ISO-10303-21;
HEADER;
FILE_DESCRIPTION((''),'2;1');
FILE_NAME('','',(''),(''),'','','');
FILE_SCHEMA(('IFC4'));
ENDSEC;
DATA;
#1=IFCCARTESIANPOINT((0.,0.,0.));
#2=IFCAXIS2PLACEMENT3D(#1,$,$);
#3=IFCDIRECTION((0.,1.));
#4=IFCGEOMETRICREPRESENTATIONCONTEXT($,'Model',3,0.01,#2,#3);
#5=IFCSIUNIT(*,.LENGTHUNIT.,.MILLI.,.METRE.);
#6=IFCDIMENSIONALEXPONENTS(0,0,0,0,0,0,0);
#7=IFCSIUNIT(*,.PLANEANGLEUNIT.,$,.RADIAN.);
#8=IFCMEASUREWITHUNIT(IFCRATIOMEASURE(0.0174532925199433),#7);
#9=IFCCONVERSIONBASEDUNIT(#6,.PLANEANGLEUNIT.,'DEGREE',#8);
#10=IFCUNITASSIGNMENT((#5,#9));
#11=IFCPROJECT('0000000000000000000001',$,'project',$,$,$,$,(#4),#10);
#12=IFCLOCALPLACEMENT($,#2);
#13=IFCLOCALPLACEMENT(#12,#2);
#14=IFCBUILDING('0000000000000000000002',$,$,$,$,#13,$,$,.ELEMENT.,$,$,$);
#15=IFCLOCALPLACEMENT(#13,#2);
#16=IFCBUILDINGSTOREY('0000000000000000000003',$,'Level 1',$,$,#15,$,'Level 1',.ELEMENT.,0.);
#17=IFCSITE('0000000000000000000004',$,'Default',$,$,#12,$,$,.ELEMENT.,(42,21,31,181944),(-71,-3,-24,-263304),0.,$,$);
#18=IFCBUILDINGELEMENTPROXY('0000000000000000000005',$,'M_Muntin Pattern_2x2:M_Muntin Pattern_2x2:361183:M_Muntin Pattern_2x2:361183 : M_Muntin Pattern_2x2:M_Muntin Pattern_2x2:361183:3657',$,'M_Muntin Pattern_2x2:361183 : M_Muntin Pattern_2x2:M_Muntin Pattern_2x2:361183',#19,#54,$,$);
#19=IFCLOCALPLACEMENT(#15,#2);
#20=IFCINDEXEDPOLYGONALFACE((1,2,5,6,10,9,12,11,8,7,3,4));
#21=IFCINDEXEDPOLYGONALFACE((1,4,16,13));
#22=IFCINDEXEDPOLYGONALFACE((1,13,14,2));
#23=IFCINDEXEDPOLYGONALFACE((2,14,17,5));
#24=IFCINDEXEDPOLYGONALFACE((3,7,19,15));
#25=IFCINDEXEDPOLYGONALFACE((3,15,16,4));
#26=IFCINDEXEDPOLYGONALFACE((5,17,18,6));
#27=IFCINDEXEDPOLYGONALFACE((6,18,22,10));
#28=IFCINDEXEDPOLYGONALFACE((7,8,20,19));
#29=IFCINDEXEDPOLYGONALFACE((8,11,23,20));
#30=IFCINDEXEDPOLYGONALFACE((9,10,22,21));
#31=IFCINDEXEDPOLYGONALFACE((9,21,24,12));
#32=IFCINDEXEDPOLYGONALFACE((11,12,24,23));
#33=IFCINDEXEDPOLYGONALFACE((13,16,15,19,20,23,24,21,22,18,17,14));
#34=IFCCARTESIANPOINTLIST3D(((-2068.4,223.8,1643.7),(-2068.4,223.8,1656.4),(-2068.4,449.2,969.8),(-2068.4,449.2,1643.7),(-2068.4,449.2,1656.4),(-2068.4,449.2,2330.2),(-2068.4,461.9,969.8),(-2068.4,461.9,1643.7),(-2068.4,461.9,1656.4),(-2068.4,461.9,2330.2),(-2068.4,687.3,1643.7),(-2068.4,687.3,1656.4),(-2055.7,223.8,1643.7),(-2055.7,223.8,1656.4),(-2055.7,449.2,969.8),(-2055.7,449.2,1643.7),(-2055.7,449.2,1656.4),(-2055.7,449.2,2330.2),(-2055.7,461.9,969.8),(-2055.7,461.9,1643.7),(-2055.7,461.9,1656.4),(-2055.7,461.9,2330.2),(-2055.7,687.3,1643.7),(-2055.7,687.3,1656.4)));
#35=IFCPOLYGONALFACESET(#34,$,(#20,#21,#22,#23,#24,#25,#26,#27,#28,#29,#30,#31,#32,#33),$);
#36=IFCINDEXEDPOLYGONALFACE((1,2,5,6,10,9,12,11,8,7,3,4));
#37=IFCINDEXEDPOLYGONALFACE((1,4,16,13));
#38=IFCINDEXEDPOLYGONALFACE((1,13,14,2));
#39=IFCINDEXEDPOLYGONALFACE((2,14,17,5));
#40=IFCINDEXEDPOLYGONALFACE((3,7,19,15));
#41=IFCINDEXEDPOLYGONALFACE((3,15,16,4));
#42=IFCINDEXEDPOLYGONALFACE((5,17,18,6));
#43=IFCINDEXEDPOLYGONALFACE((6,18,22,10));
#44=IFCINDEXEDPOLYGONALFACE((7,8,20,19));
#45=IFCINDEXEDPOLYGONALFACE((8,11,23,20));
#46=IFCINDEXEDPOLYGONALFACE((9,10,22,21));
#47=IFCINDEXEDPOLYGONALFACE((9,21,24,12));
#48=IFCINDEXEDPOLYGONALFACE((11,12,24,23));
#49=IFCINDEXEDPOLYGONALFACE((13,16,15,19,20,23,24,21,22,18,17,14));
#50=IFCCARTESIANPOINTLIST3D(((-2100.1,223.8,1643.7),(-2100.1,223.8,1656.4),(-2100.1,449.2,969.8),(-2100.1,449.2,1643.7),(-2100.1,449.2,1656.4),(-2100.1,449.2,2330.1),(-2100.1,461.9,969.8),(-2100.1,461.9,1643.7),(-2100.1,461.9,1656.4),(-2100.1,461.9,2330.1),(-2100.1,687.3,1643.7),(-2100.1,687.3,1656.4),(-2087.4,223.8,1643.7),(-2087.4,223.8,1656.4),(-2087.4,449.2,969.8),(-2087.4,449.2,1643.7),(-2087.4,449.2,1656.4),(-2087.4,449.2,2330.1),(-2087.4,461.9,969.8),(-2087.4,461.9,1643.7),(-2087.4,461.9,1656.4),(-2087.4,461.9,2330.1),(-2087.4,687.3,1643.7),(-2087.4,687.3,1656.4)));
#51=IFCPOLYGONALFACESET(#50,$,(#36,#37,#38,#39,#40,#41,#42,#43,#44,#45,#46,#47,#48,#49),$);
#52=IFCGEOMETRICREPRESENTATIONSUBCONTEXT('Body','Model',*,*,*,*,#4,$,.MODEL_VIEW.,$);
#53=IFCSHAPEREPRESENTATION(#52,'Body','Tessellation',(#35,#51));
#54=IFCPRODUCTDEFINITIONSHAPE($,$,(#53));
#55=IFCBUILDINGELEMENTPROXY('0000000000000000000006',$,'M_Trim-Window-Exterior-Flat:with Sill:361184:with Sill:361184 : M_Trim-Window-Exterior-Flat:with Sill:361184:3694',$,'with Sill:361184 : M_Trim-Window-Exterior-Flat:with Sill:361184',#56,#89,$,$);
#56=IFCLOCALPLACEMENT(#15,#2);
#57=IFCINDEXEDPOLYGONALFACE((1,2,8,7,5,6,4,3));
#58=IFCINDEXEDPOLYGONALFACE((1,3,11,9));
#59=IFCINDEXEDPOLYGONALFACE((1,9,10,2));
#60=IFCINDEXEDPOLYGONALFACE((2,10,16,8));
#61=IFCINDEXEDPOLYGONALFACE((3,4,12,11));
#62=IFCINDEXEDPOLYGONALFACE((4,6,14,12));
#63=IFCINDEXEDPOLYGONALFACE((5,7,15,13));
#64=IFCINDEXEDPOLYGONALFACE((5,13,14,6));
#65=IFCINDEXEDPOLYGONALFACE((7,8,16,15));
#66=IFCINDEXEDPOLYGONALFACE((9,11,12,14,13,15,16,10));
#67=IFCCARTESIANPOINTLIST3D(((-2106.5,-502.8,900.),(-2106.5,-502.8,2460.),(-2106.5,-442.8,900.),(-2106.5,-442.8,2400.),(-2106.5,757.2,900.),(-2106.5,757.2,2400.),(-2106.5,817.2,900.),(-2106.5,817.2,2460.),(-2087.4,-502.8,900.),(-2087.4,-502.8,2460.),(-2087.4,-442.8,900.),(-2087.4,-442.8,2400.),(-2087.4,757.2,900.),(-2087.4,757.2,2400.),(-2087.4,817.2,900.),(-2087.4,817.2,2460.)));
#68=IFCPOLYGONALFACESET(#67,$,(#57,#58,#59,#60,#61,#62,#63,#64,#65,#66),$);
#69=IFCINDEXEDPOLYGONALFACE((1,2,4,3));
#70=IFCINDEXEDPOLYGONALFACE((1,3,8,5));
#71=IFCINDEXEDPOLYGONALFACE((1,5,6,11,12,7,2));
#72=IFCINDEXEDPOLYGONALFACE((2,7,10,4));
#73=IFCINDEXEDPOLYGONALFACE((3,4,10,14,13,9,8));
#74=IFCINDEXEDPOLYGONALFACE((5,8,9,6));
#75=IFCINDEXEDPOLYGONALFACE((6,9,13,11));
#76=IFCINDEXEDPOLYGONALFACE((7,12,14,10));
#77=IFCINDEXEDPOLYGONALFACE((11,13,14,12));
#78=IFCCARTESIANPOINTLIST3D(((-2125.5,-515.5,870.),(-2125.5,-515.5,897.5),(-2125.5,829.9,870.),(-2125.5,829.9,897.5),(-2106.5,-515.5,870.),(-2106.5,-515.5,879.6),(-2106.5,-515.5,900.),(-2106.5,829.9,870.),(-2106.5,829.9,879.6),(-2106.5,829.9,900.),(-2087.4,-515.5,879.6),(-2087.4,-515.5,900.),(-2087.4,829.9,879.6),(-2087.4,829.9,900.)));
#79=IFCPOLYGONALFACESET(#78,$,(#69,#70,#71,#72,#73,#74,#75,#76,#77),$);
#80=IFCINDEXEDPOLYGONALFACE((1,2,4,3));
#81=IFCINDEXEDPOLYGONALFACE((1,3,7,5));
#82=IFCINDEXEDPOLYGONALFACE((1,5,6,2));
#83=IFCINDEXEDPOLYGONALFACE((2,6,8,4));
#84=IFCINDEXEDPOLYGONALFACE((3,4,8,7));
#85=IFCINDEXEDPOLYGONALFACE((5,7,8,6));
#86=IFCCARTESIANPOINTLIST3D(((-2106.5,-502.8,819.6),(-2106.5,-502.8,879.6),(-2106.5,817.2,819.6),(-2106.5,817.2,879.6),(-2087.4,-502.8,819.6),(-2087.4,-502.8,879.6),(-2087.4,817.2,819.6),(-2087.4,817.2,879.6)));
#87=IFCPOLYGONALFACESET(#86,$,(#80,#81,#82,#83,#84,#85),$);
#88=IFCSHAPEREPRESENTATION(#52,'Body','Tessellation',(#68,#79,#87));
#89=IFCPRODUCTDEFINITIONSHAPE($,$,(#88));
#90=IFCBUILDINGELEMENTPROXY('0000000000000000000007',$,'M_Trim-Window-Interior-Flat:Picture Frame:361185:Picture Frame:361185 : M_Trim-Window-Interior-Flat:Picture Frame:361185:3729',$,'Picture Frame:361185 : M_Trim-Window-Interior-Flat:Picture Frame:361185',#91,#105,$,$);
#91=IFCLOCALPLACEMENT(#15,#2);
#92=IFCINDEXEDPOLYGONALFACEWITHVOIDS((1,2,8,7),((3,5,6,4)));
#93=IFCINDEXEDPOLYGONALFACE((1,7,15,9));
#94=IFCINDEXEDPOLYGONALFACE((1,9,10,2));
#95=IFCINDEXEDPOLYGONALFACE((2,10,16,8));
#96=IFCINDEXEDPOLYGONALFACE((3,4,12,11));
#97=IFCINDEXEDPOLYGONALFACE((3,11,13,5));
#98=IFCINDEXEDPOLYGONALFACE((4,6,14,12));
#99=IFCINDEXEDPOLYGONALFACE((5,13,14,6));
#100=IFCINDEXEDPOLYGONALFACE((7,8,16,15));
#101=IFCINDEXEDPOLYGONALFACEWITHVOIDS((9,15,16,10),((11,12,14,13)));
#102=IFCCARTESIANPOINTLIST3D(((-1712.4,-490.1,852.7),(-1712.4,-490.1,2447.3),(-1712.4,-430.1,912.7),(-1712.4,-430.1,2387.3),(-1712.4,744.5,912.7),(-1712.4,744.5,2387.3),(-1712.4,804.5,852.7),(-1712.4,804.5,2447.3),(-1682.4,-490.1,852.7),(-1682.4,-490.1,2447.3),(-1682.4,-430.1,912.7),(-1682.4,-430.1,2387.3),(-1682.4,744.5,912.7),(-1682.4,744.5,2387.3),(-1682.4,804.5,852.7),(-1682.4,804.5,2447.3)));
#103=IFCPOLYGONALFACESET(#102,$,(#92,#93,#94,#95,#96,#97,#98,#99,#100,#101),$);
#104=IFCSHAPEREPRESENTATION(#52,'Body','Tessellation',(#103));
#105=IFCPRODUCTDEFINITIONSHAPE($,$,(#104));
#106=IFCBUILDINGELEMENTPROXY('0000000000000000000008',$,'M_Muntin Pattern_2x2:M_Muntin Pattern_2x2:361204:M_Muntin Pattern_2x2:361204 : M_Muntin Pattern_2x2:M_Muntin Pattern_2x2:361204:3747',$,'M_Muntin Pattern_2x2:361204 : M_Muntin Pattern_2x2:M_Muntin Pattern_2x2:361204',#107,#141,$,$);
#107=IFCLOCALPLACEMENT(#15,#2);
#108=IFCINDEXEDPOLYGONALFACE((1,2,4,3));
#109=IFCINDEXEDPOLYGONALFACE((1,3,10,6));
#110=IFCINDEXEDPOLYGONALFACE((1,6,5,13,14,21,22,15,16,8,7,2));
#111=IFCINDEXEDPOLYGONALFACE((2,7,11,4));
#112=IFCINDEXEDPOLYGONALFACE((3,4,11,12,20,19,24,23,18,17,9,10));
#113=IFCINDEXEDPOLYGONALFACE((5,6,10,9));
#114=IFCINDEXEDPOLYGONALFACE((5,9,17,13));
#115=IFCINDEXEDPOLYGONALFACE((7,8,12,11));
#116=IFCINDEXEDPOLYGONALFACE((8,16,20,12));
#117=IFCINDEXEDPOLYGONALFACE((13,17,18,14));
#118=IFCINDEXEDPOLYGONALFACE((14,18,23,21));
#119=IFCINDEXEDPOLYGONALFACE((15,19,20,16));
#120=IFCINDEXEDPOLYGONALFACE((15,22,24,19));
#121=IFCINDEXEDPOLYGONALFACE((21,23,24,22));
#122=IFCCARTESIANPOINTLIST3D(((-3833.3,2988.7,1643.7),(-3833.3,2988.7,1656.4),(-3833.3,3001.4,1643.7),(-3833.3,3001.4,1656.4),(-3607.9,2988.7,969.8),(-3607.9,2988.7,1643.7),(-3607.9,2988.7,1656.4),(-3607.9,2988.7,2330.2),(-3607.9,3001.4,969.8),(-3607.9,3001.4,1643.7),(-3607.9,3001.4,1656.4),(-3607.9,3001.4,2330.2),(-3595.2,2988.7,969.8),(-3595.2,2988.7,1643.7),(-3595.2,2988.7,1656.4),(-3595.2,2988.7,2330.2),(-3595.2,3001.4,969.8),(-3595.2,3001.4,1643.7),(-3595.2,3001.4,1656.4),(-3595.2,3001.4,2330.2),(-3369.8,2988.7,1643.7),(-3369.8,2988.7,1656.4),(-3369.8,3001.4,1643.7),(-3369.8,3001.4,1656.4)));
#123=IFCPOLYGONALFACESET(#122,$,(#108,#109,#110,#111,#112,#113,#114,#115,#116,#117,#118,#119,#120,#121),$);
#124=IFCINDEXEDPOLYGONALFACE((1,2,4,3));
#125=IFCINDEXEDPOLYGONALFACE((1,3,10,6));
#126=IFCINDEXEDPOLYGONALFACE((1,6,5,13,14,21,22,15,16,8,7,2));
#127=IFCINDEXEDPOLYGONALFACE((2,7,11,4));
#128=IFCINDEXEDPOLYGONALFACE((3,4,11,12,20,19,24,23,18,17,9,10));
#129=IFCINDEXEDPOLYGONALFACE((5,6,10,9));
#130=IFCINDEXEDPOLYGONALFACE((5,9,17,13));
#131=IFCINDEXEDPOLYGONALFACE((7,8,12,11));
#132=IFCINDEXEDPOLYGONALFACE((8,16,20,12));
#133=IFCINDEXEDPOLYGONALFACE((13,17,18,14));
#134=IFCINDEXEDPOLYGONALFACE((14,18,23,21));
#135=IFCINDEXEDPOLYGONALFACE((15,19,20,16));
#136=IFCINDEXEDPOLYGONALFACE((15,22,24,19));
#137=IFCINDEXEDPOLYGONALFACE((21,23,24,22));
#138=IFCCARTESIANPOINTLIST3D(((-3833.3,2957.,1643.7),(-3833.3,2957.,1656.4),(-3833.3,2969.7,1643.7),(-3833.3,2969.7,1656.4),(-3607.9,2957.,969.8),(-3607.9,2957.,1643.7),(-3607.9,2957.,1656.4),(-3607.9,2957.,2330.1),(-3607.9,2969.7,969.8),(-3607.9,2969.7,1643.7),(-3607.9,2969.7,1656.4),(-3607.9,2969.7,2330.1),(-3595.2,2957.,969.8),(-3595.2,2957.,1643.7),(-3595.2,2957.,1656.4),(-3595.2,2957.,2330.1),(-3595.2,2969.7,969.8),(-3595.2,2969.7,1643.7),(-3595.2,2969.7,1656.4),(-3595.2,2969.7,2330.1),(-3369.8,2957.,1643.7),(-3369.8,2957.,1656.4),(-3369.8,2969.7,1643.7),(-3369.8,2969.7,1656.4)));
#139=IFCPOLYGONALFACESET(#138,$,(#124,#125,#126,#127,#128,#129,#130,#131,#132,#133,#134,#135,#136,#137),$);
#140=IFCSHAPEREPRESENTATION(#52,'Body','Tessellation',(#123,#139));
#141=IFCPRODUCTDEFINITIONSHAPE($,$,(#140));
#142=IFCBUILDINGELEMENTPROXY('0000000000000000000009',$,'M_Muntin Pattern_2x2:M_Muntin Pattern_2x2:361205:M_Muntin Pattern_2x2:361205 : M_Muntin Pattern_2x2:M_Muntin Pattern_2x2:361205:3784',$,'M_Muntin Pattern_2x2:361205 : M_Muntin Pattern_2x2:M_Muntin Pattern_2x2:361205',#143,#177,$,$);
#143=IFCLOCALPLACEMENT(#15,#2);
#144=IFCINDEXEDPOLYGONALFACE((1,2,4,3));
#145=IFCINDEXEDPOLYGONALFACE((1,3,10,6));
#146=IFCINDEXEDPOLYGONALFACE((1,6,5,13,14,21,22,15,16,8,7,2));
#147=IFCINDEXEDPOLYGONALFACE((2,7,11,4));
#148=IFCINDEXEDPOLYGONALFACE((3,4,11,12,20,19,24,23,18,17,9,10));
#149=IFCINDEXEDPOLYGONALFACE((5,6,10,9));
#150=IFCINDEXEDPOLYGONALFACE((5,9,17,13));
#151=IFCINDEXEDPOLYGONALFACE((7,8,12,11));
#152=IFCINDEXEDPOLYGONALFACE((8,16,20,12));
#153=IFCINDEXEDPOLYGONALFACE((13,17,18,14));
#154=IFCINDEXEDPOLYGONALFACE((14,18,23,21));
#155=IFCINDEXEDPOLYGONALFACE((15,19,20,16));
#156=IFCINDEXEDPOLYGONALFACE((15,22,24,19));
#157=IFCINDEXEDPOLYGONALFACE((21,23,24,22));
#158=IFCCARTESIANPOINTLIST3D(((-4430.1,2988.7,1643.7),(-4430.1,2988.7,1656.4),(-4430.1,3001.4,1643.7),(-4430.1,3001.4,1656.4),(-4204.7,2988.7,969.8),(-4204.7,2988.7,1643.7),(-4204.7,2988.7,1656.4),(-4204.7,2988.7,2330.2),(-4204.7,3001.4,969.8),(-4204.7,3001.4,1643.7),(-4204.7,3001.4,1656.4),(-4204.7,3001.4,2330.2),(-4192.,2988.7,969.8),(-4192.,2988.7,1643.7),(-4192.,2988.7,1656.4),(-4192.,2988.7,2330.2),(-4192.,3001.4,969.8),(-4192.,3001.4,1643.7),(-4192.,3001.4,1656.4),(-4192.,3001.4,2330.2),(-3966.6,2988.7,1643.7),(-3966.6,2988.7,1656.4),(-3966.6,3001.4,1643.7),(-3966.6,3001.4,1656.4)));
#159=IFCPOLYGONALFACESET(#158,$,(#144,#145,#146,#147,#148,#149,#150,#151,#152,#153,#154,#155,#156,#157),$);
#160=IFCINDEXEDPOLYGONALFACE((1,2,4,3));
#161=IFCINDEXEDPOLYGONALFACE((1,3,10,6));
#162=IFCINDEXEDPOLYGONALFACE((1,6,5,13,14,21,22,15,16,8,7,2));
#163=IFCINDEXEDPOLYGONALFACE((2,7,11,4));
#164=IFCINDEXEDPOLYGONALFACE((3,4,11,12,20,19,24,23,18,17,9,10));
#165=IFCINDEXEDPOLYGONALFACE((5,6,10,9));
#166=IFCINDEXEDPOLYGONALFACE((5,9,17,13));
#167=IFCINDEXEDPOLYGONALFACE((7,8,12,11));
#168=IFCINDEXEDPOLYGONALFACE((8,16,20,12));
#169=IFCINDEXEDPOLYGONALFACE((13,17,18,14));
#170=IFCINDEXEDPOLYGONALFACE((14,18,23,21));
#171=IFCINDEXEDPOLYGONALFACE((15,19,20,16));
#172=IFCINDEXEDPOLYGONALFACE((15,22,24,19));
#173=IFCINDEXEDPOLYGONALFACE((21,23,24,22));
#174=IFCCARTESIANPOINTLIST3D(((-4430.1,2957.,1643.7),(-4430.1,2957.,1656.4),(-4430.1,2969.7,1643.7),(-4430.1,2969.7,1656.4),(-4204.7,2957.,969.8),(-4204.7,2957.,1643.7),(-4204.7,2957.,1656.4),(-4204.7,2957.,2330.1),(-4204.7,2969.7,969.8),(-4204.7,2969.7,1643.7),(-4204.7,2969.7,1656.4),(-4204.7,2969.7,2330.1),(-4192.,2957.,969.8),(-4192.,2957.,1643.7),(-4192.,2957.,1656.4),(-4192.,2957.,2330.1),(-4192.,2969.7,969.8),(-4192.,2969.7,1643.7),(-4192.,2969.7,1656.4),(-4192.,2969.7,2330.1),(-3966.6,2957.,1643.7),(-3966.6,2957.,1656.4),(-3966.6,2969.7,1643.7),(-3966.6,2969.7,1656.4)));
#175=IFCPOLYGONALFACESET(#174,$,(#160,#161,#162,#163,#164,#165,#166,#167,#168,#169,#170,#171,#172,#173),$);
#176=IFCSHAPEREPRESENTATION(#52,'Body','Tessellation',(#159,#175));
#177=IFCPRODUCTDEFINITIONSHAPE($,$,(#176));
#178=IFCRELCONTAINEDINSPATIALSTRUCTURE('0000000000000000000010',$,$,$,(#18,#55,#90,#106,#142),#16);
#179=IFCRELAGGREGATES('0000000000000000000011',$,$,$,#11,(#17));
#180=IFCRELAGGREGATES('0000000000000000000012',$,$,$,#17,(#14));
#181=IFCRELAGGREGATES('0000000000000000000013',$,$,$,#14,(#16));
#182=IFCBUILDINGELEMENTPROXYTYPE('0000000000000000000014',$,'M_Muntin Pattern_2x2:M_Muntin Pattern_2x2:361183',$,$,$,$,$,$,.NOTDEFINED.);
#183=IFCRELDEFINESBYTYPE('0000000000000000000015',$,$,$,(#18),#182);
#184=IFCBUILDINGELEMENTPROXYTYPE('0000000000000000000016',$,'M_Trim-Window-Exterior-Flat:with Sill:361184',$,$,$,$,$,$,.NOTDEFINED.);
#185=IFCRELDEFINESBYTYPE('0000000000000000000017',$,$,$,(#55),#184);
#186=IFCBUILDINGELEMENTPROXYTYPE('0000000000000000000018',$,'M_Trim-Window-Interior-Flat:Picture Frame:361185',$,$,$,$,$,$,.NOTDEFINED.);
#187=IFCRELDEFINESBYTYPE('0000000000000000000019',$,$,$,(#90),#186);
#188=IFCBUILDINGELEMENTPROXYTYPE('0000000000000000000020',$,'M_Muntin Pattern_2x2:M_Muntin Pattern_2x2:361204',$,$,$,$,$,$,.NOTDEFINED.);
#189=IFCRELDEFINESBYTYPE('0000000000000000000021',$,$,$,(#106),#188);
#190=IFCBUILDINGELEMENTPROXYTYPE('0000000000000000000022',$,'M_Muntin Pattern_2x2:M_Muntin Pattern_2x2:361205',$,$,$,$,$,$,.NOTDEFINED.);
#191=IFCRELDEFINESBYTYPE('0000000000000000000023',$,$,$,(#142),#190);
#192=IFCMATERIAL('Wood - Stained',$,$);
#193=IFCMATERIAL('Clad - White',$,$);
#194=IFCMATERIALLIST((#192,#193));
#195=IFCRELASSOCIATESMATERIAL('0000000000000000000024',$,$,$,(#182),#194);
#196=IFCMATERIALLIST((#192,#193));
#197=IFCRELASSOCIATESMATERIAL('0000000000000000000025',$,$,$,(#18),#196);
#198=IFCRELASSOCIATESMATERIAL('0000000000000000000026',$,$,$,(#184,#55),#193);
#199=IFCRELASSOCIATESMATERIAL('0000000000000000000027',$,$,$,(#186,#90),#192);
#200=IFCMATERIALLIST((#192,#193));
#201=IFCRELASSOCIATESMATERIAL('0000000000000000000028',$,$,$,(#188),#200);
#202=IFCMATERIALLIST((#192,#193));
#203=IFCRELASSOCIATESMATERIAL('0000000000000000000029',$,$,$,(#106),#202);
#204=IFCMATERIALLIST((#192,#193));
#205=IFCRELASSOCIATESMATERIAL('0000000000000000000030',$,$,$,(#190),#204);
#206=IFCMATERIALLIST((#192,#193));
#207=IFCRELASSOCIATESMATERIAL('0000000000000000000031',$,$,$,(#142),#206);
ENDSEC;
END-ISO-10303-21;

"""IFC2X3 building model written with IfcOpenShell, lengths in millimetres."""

from ifc_helpers import new_model, entity, si_unit, converted_unit, direction, frame, origin, origin_2d_with_axis, place, context, subcontext, project, spatial, polyline, rectangle, outline, extrude, source, transform, mapped, material, material_list, type_object, type_shapes, element, save


model = new_model("IFC2X3")

# Units and contexts
model_context = context("Model", 3, precision=0.01, world=origin(), true_north=direction((0.0, 1.0)))
body_context = subcontext(model_context, "Body", "Model", "MODEL_VIEW")
ifc_project = project(units=[si_unit("LENGTHUNIT", "METRE", prefix="MILLI"), converted_unit("PLANEANGLEUNIT", "DEGREE", entity("IfcRatioMeasure", 0.0174532925199433), si_unit("PLANEANGLEUNIT", "RADIAN"), dimensions=[0, 0, 0, 0, 0, 0, 0])], contexts=[model_context])

# Site, building, storey
site_placement = place(None, origin())
site = spatial("IfcSite", under=ifc_project, at=site_placement, Name="Default", CompositionType="ELEMENT", RefLatitude=(42, 21, 31, 181944), RefLongitude=(-71, -3, -24, -263304), RefElevation=0.0)
building_placement = place(site_placement, origin())
building = spatial("IfcBuilding", under=site, at=building_placement, CompositionType="ELEMENT")
storey_placement = place(building_placement, origin())
storey = spatial("IfcBuildingStorey", under=building, at=storey_placement, Name="Level 1", LongName="Level 1", CompositionType="ELEMENT", Elevation=0.0)

# Building element proxies
ifc_material_1 = material(Name="Wood - Stained")
ifc_material_2 = material(Name="Clad - White")
ifc_material_list_1 = material_list([ifc_material_1, ifc_material_2])
ifc_material_list_2 = material_list([ifc_material_1, ifc_material_2])
building_element_proxy_type_1 = type_object("IfcBuildingElementProxyType", Name="M_Muntin Pattern_2x2:M_Muntin Pattern_2x2:361183", PredefinedType="NOTDEFINED", material=ifc_material_list_2)
shared_shape_1 = source(origin(), body_context, "Body", "SweptSolid", [
    extrude(outline(polyline([(-6.4, -680.1), (6.3, -680.1), (6.3, -6.4), (231.7, -6.4), (231.7, 6.3), (6.3, 6.3), (6.3, 680.2), (-6.4, 680.2), (-6.4, 6.3), (-231.7, 6.3), (-231.7, -6.4), (-6.4, -6.4), (-6.4, -680.1)])), frame((-2068.4, 455.6, 1650.0), z_axis=(1.0, 0.0, 0.0), x_axis=(0.0, -1.0, 0.0)), (0.0, 0.0, 1.0), 12.7),
    extrude(outline(polyline([(-6.4, -680.1), (6.3, -680.1), (6.3, -6.4), (231.7, -6.4), (231.7, 6.3), (6.3, 6.3), (6.3, 680.2), (-6.4, 680.2), (-6.4, 6.3), (-231.7, 6.3), (-231.7, -6.4), (-6.4, -6.4), (-6.4, -680.1)])), frame((-2100.1, 455.6, 1650.0), z_axis=(1.0, 0.0, 0.0), x_axis=(0.0, -1.0, 0.0)), (0.0, 0.0, 1.0), 12.7),
])
type_shapes(building_element_proxy_type_1, [shared_shape_1])
proxy_1_placement = place(storey_placement, origin())
element("IfcBuildingElementProxy", 1, at=proxy_1_placement, inside=storey, type_object=building_element_proxy_type_1, material=ifc_material_list_1, Name="M_Muntin Pattern_2x2:M_Muntin Pattern_2x2:361183:M_Muntin Pattern_2x2:361183 : M_Muntin Pattern_2x2:M_Muntin Pattern_2x2:361183:3657", ObjectType="M_Muntin Pattern_2x2:361183 : M_Muntin Pattern_2x2:M_Muntin Pattern_2x2:361183", context=body_context, shape_type="MappedRepresentation", body=[
    mapped(shared_shape_1, transform((0.0, 0.0, 0.0), scale=1.0)),
])
building_element_proxy_type_2 = type_object("IfcBuildingElementProxyType", Name="M_Trim-Window-Exterior-Flat:with Sill:361184", PredefinedType="NOTDEFINED", material=ifc_material_2)
shared_shape_2 = source(origin(), body_context, "Body", "SweptSolid", [
    extrude(outline(polyline([(-765.0, -660.0), (795.0, -660.0), (795.0, 660.0), (-765.0, 660.0), (-765.0, 600.0), (735.0, 600.0), (735.0, -600.0), (-765.0, -600.0), (-765.0, -660.0)])), frame((-2106.5, 157.2, 1665.0), z_axis=(1.0, 0.0, 0.0), x_axis=(0.0, 0.0, 1.0)), (0.0, 0.0, 1.0), 19.1),
    extrude(outline(polyline([(0.0, -15.2), (19.0, -15.2), (19.0, 12.3), (0.0, 14.8), (-19.0, 14.8), (-19.0, -5.7), (0.0, -5.7), (0.0, -15.2)])), frame((-2106.5, -515.5, 885.2), z_axis=(0.0, 1.0, 0.0), x_axis=(-1.0, 0.0, 0.0)), (0.0, 0.0, 1.0), 1345.4),
    extrude(rectangle(XDim=19.1, YDim=1320.0, at=origin_2d_with_axis()), frame((-2097.0, 157.2, 819.6)), (0.0, 0.0, 1.0), 60.0),
])
type_shapes(building_element_proxy_type_2, [shared_shape_2])
proxy_2_placement = place(storey_placement, origin())
element("IfcBuildingElementProxy", 2, at=proxy_2_placement, inside=storey, type_object=building_element_proxy_type_2, material=ifc_material_2, Name="M_Trim-Window-Exterior-Flat:with Sill:361184:with Sill:361184 : M_Trim-Window-Exterior-Flat:with Sill:361184:3694", ObjectType="with Sill:361184 : M_Trim-Window-Exterior-Flat:with Sill:361184", context=body_context, shape_type="MappedRepresentation", body=[
    mapped(shared_shape_2, transform((0.0, 0.0, 0.0), scale=1.0)),
])
building_element_proxy_type_3 = type_object("IfcBuildingElementProxyType", Name="M_Trim-Window-Interior-Flat:Picture Frame:361185", PredefinedType="NOTDEFINED", material=ifc_material_1)
shared_shape_3 = source(origin(), body_context, "Body", "SweptSolid", [
    extrude(outline(polyline([(-797.3, -647.3), (797.3, -647.3), (797.3, 647.3), (-797.3, 647.3), (-797.3, -647.3)]), holes=[polyline([(737.3, 587.3), (737.3, -587.3), (-737.3, -587.3), (-737.3, 587.3), (737.3, 587.3)])]), frame((-1712.4, 157.2, 1650.0), z_axis=(1.0, 0.0, 0.0), x_axis=(0.0, 0.0, -1.0)), (0.0, 0.0, 1.0), 30.0),
])
type_shapes(building_element_proxy_type_3, [shared_shape_3])
proxy_3_placement = place(storey_placement, origin())
element("IfcBuildingElementProxy", 3, at=proxy_3_placement, inside=storey, type_object=building_element_proxy_type_3, material=ifc_material_1, Name="M_Trim-Window-Interior-Flat:Picture Frame:361185:Picture Frame:361185 : M_Trim-Window-Interior-Flat:Picture Frame:361185:3729", ObjectType="Picture Frame:361185 : M_Trim-Window-Interior-Flat:Picture Frame:361185", context=body_context, shape_type="MappedRepresentation", body=[
    mapped(shared_shape_3, transform((0.0, 0.0, 0.0), scale=1.0)),
])
ifc_material_list_3 = material_list([ifc_material_1, ifc_material_2])
ifc_material_list_4 = material_list([ifc_material_1, ifc_material_2])
building_element_proxy_type_4 = type_object("IfcBuildingElementProxyType", Name="M_Muntin Pattern_2x2:M_Muntin Pattern_2x2:361204", PredefinedType="NOTDEFINED", material=ifc_material_list_4)
shared_shape_4 = source(origin(), body_context, "Body", "SweptSolid", [
    extrude(outline(polyline([(-680.2, 6.4), (-680.2, -6.3), (-6.4, -6.3), (-6.4, -231.7), (6.3, -231.7), (6.3, -6.3), (680.2, -6.3), (680.2, 6.4), (6.3, 6.4), (6.3, 231.7), (-6.4, 231.7), (-6.4, 6.4), (-680.2, 6.4)])), frame((-3601.5, 2988.7, 1650.0), z_axis=(0.0, -1.0, 0.0), x_axis=(0.0, 0.0, -1.0)), (0.0, 0.0, -1.0), 12.7),
    extrude(outline(polyline([(-680.1, 6.4), (-680.1, -6.3), (-6.4, -6.3), (-6.4, -231.7), (6.3, -231.7), (6.3, -6.3), (680.2, -6.3), (680.2, 6.4), (6.3, 6.4), (6.3, 231.7), (-6.4, 231.7), (-6.4, 6.4), (-680.1, 6.4)])), frame((-3601.5, 2957.0, 1650.0), z_axis=(0.0, -1.0, 0.0), x_axis=(0.0, 0.0, -1.0)), (0.0, 0.0, -1.0), 12.7),
])
type_shapes(building_element_proxy_type_4, [shared_shape_4])
proxy_4_placement = place(storey_placement, origin())
element("IfcBuildingElementProxy", 4, at=proxy_4_placement, inside=storey, type_object=building_element_proxy_type_4, material=ifc_material_list_3, Name="M_Muntin Pattern_2x2:M_Muntin Pattern_2x2:361204:M_Muntin Pattern_2x2:361204 : M_Muntin Pattern_2x2:M_Muntin Pattern_2x2:361204:3747", ObjectType="M_Muntin Pattern_2x2:361204 : M_Muntin Pattern_2x2:M_Muntin Pattern_2x2:361204", context=body_context, shape_type="MappedRepresentation", body=[
    mapped(shared_shape_4, transform((0.0, 0.0, 0.0), scale=1.0)),
])
ifc_material_list_5 = material_list([ifc_material_1, ifc_material_2])
ifc_material_list_6 = material_list([ifc_material_1, ifc_material_2])
building_element_proxy_type_5 = type_object("IfcBuildingElementProxyType", Name="M_Muntin Pattern_2x2:M_Muntin Pattern_2x2:361205", PredefinedType="NOTDEFINED", material=ifc_material_list_6)
shared_shape_5 = source(origin(), body_context, "Body", "SweptSolid", [
    extrude(outline(polyline([(-6.4, -680.1), (6.3, -680.1), (6.3, -6.4), (231.7, -6.4), (231.7, 6.3), (6.3, 6.3), (6.3, 680.2), (-6.4, 680.2), (-6.4, 6.3), (-231.7, 6.3), (-231.7, -6.4), (-6.4, -6.4), (-6.4, -680.1)])), frame((-4198.4, 2988.7, 1650.0), z_axis=(0.0, 1.0, 0.0), x_axis=(1.0, 0.0, 0.0)), (0.0, 0.0, 1.0), 12.7),
    extrude(outline(polyline([(-6.4, -680.1), (6.3, -680.1), (6.3, -6.4), (231.7, -6.4), (231.7, 6.3), (6.3, 6.3), (6.3, 680.2), (-6.4, 680.2), (-6.4, 6.3), (-231.7, 6.3), (-231.7, -6.4), (-6.4, -6.4), (-6.4, -680.1)])), frame((-4198.4, 2957.0, 1650.0), z_axis=(0.0, 1.0, 0.0), x_axis=(1.0, 0.0, 0.0)), (0.0, 0.0, 1.0), 12.7),
])
type_shapes(building_element_proxy_type_5, [shared_shape_5])
proxy_5_placement = place(storey_placement, origin())
element("IfcBuildingElementProxy", 5, at=proxy_5_placement, inside=storey, type_object=building_element_proxy_type_5, material=ifc_material_list_5, Name="M_Muntin Pattern_2x2:M_Muntin Pattern_2x2:361205:M_Muntin Pattern_2x2:361205 : M_Muntin Pattern_2x2:M_Muntin Pattern_2x2:361205:3784", ObjectType="M_Muntin Pattern_2x2:361205 : M_Muntin Pattern_2x2:M_Muntin Pattern_2x2:361205", context=body_context, shape_type="MappedRepresentation", body=[
    mapped(shared_shape_5, transform((0.0, 0.0, 0.0), scale=1.0)),
])

save(model, "model.ifc")
